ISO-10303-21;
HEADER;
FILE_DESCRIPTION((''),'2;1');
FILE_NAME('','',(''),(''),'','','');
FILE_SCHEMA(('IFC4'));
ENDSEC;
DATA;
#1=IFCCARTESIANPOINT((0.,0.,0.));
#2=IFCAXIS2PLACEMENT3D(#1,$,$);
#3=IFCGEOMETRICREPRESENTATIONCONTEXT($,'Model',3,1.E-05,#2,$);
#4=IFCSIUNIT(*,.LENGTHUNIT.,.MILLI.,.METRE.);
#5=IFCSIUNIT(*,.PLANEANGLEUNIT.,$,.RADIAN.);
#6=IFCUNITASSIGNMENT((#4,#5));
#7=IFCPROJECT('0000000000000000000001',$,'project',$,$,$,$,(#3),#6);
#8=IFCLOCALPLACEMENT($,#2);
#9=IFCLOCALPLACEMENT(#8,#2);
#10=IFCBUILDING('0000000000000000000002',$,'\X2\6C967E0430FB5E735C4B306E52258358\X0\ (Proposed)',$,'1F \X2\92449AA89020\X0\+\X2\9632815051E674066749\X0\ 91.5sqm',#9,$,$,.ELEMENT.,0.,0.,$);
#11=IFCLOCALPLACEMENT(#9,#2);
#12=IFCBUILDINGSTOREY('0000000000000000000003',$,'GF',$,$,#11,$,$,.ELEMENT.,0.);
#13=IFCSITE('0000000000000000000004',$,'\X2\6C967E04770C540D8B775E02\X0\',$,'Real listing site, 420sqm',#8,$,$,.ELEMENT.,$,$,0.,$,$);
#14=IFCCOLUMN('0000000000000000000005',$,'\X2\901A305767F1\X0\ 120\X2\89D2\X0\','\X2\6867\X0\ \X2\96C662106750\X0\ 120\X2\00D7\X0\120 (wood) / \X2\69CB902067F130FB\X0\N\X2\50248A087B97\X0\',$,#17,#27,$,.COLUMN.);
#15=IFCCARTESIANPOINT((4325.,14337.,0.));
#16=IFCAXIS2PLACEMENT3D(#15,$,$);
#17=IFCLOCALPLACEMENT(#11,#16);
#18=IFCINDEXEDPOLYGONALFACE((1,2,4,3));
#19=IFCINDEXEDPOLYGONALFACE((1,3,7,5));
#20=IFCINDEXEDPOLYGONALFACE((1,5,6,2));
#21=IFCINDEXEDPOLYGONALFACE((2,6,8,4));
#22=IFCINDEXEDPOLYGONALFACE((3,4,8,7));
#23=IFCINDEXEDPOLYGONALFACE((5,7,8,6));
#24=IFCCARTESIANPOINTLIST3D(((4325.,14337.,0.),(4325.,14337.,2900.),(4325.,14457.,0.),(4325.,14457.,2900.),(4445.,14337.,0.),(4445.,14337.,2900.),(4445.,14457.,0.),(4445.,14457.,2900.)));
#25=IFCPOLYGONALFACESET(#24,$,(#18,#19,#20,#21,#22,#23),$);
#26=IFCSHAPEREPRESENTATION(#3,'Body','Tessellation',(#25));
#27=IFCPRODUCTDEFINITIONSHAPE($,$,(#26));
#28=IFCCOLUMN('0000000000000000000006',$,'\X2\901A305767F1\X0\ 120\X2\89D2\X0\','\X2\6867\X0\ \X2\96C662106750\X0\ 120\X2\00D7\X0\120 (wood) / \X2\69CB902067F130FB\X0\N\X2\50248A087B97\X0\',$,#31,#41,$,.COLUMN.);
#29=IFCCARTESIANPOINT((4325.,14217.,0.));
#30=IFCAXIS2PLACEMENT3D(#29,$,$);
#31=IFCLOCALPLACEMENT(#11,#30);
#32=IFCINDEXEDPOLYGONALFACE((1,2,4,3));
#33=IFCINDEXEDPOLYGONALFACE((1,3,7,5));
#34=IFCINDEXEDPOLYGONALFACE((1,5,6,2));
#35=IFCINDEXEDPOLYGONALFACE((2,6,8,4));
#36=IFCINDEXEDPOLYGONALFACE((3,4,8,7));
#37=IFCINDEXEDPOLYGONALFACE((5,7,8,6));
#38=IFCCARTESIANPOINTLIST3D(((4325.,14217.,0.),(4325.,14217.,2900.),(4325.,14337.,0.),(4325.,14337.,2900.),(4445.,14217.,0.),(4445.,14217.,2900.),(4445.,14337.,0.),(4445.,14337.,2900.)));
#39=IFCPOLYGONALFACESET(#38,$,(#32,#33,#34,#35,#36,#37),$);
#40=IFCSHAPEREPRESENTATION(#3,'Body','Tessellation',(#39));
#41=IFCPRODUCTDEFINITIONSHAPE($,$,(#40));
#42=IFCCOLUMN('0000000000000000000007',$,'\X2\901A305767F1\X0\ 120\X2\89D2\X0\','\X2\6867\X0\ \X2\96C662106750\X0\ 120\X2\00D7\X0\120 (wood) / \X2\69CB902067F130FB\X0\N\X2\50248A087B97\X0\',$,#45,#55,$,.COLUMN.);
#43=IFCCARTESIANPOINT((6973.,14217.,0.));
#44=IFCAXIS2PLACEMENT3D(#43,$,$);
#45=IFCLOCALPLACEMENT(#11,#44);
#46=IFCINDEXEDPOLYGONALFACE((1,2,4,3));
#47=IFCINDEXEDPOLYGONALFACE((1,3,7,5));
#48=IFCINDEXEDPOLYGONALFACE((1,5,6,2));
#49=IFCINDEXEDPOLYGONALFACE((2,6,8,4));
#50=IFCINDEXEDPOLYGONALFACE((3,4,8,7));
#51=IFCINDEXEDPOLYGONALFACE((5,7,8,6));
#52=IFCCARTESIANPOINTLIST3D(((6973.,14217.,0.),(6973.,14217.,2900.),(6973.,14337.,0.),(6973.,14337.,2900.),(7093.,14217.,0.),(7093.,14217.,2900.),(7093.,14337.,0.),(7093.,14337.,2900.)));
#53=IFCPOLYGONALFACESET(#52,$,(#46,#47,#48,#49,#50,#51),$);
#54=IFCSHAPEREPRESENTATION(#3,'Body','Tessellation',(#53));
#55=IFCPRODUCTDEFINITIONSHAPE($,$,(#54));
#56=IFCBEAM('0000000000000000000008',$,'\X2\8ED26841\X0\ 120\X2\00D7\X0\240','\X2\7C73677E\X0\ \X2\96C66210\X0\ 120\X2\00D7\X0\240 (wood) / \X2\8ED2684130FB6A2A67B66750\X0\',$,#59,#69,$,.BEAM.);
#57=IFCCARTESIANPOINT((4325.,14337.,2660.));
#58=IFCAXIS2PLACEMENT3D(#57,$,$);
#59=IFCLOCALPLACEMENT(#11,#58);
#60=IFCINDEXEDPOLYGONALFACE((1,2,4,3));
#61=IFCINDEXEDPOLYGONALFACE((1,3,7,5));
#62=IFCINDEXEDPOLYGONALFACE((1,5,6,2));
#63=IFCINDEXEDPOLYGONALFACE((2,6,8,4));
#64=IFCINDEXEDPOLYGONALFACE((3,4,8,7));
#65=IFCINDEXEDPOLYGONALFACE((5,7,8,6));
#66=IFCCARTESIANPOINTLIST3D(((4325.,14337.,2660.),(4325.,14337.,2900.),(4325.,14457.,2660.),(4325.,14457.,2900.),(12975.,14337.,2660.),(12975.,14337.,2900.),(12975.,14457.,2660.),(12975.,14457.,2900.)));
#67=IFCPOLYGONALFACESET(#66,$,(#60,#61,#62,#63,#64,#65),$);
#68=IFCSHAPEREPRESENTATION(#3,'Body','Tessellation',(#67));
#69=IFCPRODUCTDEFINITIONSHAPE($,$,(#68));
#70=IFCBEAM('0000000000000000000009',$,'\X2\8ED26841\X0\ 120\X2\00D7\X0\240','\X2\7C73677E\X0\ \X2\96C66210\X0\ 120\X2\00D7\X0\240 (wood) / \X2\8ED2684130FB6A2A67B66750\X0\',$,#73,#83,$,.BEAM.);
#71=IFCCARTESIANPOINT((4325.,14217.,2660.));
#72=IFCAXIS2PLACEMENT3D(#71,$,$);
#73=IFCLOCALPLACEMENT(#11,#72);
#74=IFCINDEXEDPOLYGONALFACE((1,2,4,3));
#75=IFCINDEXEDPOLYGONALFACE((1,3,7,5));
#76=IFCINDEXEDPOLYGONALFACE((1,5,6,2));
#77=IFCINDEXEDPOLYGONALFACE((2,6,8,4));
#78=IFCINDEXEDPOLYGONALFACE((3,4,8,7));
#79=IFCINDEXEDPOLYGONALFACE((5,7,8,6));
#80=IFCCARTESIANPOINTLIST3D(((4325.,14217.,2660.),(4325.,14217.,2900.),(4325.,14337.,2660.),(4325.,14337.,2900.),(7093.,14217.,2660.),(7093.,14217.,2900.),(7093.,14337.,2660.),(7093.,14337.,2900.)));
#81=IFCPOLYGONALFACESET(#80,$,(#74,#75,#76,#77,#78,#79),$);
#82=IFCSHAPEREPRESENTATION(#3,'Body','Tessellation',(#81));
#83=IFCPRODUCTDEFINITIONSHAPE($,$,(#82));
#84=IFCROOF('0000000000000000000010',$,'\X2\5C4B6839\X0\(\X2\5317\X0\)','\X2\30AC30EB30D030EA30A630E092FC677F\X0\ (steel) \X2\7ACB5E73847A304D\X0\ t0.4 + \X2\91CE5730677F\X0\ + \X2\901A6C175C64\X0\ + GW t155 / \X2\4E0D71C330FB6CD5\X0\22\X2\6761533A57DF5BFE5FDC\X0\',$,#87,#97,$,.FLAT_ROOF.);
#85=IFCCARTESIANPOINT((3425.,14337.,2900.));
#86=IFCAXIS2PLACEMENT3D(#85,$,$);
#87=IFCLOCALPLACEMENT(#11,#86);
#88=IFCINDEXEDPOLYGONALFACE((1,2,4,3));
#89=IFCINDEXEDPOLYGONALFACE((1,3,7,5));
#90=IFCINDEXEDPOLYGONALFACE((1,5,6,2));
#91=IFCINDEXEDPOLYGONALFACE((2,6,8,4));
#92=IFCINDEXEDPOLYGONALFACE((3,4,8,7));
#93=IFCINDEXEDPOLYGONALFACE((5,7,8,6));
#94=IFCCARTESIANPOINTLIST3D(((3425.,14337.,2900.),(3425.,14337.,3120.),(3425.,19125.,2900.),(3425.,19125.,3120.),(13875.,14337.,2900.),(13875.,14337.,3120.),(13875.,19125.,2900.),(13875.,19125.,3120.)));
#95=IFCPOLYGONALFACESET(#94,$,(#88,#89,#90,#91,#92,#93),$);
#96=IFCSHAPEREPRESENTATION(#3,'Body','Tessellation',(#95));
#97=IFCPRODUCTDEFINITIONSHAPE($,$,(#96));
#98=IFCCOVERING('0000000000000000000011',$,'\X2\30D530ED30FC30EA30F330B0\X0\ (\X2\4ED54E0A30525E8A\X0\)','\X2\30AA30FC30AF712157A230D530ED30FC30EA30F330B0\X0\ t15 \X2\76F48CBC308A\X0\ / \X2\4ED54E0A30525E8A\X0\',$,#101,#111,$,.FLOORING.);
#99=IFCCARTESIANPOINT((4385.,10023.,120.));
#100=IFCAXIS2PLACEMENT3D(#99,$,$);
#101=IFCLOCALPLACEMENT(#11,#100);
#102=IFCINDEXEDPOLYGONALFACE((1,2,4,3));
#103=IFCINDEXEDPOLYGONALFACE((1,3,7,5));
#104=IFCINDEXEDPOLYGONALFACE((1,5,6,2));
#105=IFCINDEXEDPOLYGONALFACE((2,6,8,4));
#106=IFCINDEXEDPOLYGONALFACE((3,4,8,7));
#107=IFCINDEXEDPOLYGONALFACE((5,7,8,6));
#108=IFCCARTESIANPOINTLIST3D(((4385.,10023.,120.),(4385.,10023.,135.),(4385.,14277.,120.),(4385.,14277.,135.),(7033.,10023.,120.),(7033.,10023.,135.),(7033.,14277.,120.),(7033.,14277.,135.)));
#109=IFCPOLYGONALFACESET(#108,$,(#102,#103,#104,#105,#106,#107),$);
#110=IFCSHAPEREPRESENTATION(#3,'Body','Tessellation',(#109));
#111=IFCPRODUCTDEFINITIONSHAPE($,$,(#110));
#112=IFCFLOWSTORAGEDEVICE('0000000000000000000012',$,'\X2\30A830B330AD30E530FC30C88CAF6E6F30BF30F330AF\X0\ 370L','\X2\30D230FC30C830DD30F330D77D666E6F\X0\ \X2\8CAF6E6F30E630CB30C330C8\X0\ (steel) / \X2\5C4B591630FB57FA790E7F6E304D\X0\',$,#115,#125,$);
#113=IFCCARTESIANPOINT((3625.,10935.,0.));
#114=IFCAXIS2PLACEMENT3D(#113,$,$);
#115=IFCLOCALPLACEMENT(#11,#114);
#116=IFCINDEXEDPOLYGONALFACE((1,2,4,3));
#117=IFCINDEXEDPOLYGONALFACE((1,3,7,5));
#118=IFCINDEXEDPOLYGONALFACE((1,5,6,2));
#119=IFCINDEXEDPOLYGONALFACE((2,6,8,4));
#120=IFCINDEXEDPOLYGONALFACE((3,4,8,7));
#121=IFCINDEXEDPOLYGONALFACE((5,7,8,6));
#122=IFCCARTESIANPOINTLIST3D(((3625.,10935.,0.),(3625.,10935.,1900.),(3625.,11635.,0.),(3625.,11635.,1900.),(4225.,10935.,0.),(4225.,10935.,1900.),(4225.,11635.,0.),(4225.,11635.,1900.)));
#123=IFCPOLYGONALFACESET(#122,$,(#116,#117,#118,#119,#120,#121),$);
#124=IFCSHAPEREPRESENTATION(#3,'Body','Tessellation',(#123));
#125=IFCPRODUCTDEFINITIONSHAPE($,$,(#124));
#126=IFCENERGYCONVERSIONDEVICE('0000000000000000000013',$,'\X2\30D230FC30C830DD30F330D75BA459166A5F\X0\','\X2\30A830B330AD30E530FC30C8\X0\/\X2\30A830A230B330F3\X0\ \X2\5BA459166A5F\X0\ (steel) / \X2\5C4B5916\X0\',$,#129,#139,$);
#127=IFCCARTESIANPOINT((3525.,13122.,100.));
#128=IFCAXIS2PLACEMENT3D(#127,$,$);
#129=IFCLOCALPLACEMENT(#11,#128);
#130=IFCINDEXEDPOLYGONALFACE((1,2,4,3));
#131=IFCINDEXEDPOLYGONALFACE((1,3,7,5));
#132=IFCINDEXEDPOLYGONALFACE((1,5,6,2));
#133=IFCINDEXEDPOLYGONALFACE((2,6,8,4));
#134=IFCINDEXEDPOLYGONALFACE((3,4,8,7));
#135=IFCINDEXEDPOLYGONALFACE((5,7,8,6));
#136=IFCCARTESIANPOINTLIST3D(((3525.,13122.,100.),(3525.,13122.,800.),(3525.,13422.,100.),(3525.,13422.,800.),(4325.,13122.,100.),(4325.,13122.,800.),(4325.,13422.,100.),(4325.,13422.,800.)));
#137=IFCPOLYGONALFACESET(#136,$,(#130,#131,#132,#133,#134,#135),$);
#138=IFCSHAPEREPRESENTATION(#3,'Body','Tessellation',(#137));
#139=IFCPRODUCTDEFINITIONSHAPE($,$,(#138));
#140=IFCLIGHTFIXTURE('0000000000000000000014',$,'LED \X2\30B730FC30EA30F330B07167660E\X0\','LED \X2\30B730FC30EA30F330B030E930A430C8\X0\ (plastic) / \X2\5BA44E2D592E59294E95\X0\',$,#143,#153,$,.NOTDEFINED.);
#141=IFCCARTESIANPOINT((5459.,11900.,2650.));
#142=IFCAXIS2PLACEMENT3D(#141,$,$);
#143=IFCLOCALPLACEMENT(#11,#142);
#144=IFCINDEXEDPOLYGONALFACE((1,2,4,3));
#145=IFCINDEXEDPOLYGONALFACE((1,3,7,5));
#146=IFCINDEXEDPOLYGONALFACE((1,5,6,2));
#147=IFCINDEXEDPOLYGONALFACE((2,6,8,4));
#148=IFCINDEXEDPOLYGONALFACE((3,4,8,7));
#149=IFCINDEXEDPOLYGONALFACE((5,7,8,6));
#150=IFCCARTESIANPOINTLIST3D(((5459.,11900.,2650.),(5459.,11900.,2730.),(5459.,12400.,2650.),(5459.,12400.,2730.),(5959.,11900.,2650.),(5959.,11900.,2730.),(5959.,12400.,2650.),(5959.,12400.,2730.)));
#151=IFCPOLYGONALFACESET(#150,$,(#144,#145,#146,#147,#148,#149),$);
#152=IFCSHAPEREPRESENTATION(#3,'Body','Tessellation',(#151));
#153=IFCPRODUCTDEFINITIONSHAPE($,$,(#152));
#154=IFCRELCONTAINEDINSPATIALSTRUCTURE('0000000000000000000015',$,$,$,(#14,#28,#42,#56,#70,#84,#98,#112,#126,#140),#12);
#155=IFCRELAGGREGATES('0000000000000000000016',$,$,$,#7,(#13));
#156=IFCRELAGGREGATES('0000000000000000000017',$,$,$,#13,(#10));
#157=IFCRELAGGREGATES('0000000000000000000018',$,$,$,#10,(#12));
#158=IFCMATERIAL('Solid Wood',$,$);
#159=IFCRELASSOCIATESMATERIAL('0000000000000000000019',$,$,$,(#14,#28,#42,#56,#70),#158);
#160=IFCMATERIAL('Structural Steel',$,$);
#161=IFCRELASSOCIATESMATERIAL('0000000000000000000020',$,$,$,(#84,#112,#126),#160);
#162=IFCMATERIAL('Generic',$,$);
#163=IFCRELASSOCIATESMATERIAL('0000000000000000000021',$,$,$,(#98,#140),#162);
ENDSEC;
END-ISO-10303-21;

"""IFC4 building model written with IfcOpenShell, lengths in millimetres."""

from ifc_helpers import new_model, si_unit, frame, frame_2d, origin, place, context, project, spatial, rectangle, extrude, material, element, save


model = new_model("IFC4")

# Units and contexts
model_context = context("Model", 3, precision=1e-05, world=origin())
ifc_project = project(units=[si_unit("LENGTHUNIT", "METRE", prefix="MILLI"), si_unit("PLANEANGLEUNIT", "RADIAN")], contexts=[model_context])

# Site, building, storey
site_placement = place(None, origin())
site = spatial("IfcSite", under=ifc_project, at=site_placement, Name="沖縄県名護市", ObjectType="Real listing site, 420sqm", CompositionType="ELEMENT", RefElevation=0.0)
building_placement = place(site_placement, origin())
building = spatial("IfcBuilding", under=site, at=building_placement, Name="沖縄・平屋の別荘 (Proposed)", ObjectType="1F 鉄骨造+防腐処理杉 91.5sqm", CompositionType="ELEMENT", ElevationOfRefHeight=0.0, ElevationOfTerrain=0.0)
storey_placement = place(building_placement, origin())
storey = spatial("IfcBuildingStorey", under=building, at=storey_placement, Name="GF", CompositionType="ELEMENT", Elevation=0.0)

# Columns
ifc_material_1 = material(Name="Solid Wood")
column_1_placement = place(storey_placement, frame((4325.0, 14337.0, 0.0)))
element("IfcColumn", 1, at=column_1_placement, inside=storey, material=ifc_material_1, Name="通し柱 120角", Description="桧 集成材 120×120 (wood) / 構造柱・N値計算", PredefinedType="COLUMN", context=model_context, shape_type="SweptSolid", body=[
    extrude(rectangle(XDim=120.0, YDim=120.0, at=frame_2d((60.0, 60.0))), frame((4325.0, 14337.0, 0.0)), (0.0, 0.0, 1.0), 2900.0),
])
column_2_placement = place(storey_placement, frame((4325.0, 14217.0, 0.0)))
element("IfcColumn", 2, at=column_2_placement, inside=storey, material=ifc_material_1, Name="通し柱 120角", Description="桧 集成材 120×120 (wood) / 構造柱・N値計算", PredefinedType="COLUMN", context=model_context, shape_type="SweptSolid", body=[
    extrude(rectangle(XDim=120.0, YDim=120.0, at=frame_2d((60.0, 60.0))), frame((4325.0, 14217.0, 0.0)), (0.0, 0.0, 1.0), 2900.0),
])
column_3_placement = place(storey_placement, frame((6973.0, 14217.0, 0.0)))
element("IfcColumn", 3, at=column_3_placement, inside=storey, material=ifc_material_1, Name="通し柱 120角", Description="桧 集成材 120×120 (wood) / 構造柱・N値計算", PredefinedType="COLUMN", context=model_context, shape_type="SweptSolid", body=[
    extrude(rectangle(XDim=120.0, YDim=120.0, at=frame_2d((60.0, 60.0))), frame((6973.0, 14217.0, 0.0)), (0.0, 0.0, 1.0), 2900.0),
])

# Beams
beam_1_placement = place(storey_placement, frame((4325.0, 14337.0, 2660.0)))
element("IfcBeam", 4, at=beam_1_placement, inside=storey, material=ifc_material_1, Name="軒桁 120×240", Description="米松 集成 120×240 (wood) / 軒桁・横架材", PredefinedType="BEAM", context=model_context, shape_type="SweptSolid", body=[
    extrude(rectangle(XDim=8650.0, YDim=120.0, at=frame_2d((4325.0, 60.0))), frame((4325.0, 14337.0, 2660.0)), (0.0, 0.0, 1.0), 240.0),
])
beam_2_placement = place(storey_placement, frame((4325.0, 14217.0, 2660.0)))
element("IfcBeam", 5, at=beam_2_placement, inside=storey, material=ifc_material_1, Name="軒桁 120×240", Description="米松 集成 120×240 (wood) / 軒桁・横架材", PredefinedType="BEAM", context=model_context, shape_type="SweptSolid", body=[
    extrude(rectangle(XDim=2768.0, YDim=120.0, at=frame_2d((1384.0, 60.0))), frame((4325.0, 14217.0, 2660.0)), (0.0, 0.0, 1.0), 240.0),
])

# Roof
ifc_material_2 = material(Name="Structural Steel")
roof_placement = place(storey_placement, frame((3425.0, 14337.0, 2900.0)))
element("IfcRoof", 6, at=roof_placement, inside=storey, material=ifc_material_2, Name="屋根(北)", Description="ガルバリウム鋼板 (steel) 立平葺き t0.4 + 野地板 + 通気層 + GW t155 / 不燃・法22条区域対応", PredefinedType="FLAT_ROOF", context=model_context, shape_type="SweptSolid", body=[
    extrude(rectangle(XDim=10450.0, YDim=4788.0, at=frame_2d((5225.0, 2394.0))), frame((3425.0, 14337.0, 2900.0)), (0.0, 0.0, 1.0), 220.0),
])

# Covering
ifc_material_3 = material(Name="Generic")
covering_placement = place(storey_placement, frame((4385.0, 10023.0, 120.0)))
element("IfcCovering", 7, at=covering_placement, inside=storey, material=ifc_material_3, Name="フローリング (仕上げ床)", Description="オーク無垢フローリング t15 直貼り / 仕上げ床", PredefinedType="FLOORING", context=model_context, shape_type="SweptSolid", body=[
    extrude(rectangle(XDim=2648.0, YDim=4254.0, at=frame_2d((1324.0, 2127.0))), frame((4385.0, 10023.0, 120.0)), (0.0, 0.0, 1.0), 15.0),
])

# Flow storage device
flow_storage_device_placement = place(storey_placement, frame((3625.0, 10935.0, 0.0)))
element("IfcFlowStorageDevice", 8, at=flow_storage_device_placement, inside=storey, material=ifc_material_2, Name="エコキュート貯湯タンク 370L", Description="ヒートポンプ給湯 貯湯ユニット (steel) / 屋外・基礎置き", context=model_context, shape_type="SweptSolid", body=[
    extrude(rectangle(XDim=600.0, YDim=700.0, at=frame_2d((300.0, 350.0))), frame((3625.0, 10935.0, 0.0)), (0.0, 0.0, 1.0), 1900.0),
])

# Energy conversion device
energy_conversion_device_placement = place(storey_placement, frame((3525.0, 13122.0, 100.0)))
element("IfcEnergyConversionDevice", 9, at=energy_conversion_device_placement, inside=storey, material=ifc_material_2, Name="ヒートポンプ室外機", Description="エコキュート/エアコン 室外機 (steel) / 屋外", context=model_context, shape_type="SweptSolid", body=[
    extrude(rectangle(XDim=800.0, YDim=300.0, at=frame_2d((400.0, 150.0))), frame((3525.0, 13122.0, 100.0)), (0.0, 0.0, 1.0), 700.0),
])

# Light fixture
light_fixture_placement = place(storey_placement, frame((5459.0, 11900.0, 2650.0)))
element("IfcLightFixture", 10, at=light_fixture_placement, inside=storey, material=ifc_material_3, Name="LED シーリング照明", Description="LED シーリングライト (plastic) / 室中央天井", PredefinedType="NOTDEFINED", context=model_context, shape_type="SweptSolid", body=[
    extrude(rectangle(XDim=500.0, YDim=500.0, at=frame_2d((250.0, 250.0))), frame((5459.0, 11900.0, 2650.0)), (0.0, 0.0, 1.0), 80.0),
])

save(model, "model.ifc")
